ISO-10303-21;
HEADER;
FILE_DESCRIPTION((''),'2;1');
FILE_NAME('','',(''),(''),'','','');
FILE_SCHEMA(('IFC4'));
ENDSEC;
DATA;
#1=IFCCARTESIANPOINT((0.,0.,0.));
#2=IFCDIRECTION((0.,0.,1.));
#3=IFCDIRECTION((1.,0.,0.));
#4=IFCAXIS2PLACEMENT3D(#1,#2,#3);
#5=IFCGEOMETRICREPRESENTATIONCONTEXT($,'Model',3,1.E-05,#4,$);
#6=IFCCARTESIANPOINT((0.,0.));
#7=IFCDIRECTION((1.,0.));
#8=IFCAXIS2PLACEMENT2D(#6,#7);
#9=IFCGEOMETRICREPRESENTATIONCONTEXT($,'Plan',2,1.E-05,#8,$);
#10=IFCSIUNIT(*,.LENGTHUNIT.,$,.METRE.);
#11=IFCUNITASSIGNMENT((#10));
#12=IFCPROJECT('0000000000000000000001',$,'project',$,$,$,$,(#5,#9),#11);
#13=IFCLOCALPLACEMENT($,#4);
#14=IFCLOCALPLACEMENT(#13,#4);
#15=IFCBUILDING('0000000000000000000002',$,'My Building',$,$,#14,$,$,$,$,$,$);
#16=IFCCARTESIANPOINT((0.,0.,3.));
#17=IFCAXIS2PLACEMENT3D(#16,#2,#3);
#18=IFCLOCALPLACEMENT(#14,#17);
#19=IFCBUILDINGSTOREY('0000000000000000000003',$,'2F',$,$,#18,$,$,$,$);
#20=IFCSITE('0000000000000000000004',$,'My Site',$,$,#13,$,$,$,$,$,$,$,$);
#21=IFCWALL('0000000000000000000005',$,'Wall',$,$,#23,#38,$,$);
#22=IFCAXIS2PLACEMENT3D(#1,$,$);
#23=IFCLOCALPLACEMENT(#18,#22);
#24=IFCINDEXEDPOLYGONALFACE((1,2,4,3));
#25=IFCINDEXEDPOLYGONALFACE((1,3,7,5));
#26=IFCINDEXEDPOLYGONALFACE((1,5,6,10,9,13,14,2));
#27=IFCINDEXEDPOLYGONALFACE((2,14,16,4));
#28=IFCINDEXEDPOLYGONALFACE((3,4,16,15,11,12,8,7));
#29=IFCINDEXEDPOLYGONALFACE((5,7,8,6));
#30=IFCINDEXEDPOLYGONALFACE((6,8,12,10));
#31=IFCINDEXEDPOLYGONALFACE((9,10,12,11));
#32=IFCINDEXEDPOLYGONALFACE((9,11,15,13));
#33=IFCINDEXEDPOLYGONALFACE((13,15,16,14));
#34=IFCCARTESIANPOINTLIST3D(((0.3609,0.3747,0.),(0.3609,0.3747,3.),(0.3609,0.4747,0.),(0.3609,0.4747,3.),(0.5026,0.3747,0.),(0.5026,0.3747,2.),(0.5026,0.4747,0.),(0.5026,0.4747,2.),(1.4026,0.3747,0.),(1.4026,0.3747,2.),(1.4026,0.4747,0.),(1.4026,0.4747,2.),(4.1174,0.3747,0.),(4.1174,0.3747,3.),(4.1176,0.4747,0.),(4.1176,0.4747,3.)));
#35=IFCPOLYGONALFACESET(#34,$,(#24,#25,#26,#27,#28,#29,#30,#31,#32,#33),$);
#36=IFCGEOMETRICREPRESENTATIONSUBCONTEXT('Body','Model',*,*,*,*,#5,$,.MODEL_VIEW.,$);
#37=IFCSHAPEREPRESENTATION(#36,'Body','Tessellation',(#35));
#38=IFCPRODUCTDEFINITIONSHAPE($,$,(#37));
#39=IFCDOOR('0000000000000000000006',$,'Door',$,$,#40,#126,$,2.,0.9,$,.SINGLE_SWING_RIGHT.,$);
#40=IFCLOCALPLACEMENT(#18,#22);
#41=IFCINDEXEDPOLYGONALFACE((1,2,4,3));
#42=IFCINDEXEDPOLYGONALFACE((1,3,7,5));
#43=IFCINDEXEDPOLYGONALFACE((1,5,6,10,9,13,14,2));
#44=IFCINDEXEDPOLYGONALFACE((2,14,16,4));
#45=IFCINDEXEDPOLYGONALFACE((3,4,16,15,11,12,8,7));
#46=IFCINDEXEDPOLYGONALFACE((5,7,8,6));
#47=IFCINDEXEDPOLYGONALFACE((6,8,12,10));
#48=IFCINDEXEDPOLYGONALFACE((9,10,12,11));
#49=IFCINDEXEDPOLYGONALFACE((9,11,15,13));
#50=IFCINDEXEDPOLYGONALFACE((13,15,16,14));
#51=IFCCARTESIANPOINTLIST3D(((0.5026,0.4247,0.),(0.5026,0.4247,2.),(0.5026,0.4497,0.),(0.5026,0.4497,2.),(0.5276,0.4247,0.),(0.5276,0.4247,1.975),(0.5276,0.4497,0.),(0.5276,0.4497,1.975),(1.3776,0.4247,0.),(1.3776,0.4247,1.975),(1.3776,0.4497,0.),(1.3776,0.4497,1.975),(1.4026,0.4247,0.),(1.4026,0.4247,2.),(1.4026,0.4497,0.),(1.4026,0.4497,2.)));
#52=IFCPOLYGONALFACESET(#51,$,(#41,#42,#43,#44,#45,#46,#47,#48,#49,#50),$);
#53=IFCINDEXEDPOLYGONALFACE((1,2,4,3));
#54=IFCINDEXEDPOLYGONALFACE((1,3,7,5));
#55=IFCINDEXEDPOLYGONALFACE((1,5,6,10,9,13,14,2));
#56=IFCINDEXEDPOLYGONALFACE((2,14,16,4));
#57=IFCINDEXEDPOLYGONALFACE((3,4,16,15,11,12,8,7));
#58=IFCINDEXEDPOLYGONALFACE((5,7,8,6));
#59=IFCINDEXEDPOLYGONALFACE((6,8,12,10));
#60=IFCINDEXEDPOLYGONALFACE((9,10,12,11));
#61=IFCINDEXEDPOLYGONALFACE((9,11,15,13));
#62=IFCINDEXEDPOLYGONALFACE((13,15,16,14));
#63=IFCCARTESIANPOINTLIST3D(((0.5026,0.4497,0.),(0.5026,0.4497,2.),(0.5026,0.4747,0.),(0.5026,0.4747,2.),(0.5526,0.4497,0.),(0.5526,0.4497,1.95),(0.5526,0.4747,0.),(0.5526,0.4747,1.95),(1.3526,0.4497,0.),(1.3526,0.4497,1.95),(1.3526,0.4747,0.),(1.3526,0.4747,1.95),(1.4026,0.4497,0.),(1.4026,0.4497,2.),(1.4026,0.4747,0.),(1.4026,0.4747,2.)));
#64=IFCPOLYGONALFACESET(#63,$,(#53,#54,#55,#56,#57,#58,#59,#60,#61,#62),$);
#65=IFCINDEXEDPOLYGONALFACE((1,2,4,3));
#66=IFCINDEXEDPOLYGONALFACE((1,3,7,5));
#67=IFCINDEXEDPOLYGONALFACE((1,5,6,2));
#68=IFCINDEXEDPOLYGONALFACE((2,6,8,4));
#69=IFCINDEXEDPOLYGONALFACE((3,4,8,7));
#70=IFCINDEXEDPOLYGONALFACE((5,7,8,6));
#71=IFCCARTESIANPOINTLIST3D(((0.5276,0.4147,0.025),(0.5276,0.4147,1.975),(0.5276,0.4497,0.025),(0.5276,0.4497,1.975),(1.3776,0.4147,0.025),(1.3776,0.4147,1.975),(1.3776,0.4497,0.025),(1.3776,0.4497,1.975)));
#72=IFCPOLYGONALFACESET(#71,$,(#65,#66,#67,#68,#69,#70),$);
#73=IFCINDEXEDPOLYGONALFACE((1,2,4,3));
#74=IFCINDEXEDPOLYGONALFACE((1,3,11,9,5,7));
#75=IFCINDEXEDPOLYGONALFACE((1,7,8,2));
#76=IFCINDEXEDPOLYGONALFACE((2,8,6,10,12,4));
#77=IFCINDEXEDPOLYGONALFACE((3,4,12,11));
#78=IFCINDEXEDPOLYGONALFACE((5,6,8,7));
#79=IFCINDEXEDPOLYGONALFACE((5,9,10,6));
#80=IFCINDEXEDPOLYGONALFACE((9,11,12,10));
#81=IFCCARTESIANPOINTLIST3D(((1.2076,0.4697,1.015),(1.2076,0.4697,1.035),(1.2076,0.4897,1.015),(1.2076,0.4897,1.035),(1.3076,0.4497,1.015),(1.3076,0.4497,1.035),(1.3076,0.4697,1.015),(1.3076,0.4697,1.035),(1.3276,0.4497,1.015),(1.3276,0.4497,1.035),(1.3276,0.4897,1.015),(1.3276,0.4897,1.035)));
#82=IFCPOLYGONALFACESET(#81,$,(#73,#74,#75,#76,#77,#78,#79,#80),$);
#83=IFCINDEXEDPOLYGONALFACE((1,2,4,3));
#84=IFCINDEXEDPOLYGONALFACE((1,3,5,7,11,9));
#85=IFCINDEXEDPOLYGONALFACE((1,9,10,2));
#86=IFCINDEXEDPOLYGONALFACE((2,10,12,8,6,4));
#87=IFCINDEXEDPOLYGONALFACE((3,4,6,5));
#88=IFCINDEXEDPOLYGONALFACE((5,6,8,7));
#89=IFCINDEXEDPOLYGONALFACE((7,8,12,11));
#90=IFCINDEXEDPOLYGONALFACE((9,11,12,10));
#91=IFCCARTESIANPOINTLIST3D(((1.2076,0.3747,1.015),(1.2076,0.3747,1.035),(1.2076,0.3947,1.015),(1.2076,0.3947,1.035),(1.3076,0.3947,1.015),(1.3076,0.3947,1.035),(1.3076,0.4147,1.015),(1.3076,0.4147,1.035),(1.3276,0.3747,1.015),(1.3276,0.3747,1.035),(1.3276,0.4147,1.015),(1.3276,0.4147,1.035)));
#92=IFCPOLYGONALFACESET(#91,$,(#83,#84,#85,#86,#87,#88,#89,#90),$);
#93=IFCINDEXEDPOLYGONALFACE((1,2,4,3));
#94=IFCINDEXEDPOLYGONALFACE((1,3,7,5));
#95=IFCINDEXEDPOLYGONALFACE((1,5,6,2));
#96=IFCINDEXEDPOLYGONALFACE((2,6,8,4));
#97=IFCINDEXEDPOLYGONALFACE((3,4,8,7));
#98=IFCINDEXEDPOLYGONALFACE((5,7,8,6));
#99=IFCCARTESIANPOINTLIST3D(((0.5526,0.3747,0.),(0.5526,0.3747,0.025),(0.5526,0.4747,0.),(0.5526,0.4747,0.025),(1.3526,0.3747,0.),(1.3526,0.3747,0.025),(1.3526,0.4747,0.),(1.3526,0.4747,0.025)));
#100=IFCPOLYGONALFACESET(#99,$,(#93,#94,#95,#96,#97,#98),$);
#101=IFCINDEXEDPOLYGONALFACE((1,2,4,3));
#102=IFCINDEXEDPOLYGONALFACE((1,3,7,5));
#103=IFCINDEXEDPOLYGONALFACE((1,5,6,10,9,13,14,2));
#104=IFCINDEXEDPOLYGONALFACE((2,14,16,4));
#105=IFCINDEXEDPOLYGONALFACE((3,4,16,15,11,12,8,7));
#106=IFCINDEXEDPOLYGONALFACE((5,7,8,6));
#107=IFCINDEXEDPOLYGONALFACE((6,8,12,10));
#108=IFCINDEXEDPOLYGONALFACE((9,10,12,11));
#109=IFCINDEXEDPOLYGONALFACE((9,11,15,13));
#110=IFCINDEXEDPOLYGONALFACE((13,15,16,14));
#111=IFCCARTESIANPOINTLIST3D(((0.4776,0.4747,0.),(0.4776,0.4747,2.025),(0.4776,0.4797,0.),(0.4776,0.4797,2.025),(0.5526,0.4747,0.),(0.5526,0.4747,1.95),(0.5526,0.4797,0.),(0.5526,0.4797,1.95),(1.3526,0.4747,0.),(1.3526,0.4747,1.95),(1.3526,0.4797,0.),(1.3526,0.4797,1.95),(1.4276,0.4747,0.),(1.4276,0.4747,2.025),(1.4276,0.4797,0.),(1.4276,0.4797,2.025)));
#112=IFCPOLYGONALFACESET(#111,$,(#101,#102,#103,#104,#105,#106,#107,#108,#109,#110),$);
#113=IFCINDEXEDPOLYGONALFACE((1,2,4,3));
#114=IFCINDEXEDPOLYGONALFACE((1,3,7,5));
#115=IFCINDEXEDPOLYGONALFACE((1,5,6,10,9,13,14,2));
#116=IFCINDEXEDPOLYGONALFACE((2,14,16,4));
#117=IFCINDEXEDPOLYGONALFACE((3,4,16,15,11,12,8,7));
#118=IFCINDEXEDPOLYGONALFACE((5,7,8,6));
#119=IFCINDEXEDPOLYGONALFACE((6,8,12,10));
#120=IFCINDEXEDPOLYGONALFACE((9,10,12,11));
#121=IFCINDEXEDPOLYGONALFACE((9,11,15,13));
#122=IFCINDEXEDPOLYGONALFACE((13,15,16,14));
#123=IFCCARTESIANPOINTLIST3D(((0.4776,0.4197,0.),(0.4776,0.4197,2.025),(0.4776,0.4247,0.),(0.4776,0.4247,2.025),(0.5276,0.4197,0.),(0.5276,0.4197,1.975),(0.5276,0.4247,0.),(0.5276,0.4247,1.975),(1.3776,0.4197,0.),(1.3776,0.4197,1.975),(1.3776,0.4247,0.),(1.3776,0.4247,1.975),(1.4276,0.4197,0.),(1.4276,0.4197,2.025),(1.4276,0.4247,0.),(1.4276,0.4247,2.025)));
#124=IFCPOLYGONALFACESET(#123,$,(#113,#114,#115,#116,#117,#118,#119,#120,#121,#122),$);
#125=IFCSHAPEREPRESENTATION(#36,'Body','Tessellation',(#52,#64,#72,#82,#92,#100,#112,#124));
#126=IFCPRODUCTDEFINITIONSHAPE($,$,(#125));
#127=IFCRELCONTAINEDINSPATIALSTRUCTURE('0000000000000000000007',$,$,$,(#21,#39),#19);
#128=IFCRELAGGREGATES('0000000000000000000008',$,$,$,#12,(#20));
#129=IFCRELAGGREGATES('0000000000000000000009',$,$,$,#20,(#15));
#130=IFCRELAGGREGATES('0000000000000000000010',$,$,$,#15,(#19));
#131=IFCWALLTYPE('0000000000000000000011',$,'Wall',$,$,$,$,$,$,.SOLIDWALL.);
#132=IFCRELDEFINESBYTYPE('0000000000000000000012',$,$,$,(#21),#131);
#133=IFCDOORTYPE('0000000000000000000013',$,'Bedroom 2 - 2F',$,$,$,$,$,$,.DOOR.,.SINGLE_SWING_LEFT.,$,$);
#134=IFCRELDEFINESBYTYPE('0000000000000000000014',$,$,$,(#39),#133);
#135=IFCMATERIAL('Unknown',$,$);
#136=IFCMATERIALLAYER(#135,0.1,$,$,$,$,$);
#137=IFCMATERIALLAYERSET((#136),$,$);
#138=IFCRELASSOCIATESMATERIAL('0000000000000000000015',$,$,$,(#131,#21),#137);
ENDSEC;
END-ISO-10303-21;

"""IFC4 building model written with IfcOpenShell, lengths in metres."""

from ifc_helpers import new_model, entity, si_unit, frame, origin_with_axes, origin_2d_with_axis, place, context, subcontext, project, spatial, line, indexed_curve, outline, extrude, shape, source, transform, mapped, material, layer, layer_set, layer_usage, type_object, type_shapes, element, fill, save


model = new_model("IFC4")

# Units and contexts
model_context = context("Model", 3, precision=1e-05, world=origin_with_axes())
plan_context = context("Plan", 2, precision=1e-05, world=origin_2d_with_axis())
body_context_1 = subcontext(model_context, "Body", "Model", "MODEL_VIEW")
body_context_2 = subcontext(plan_context, "Body", "Plan", "PLAN_VIEW")
ifc_project = project(units=[si_unit("LENGTHUNIT", "METRE")], contexts=[model_context, plan_context])

# Site, building, storey
site_placement = place(None, origin_with_axes())
site = spatial("IfcSite", under=ifc_project, at=site_placement, Name="My Site")
building_placement = place(site_placement, origin_with_axes())
building = spatial("IfcBuilding", under=site, at=building_placement, Name="My Building")
storey_placement = place(building_placement, frame((0.0, 0.0, 3.0), z_axis=(0.0, 0.0, 1.0), x_axis=(1.0, 0.0, 0.0)))
storey = spatial("IfcBuildingStorey", under=building, at=storey_placement, Name="2F")

# Shared definitions
ifc_material = material(Name="Unknown")

# Shared definitions
ifc_layer_1 = layer(ifc_material, 0.1)
ifc_layer_set_1 = layer_set([ifc_layer_1])
wall_type = type_object("IfcWallType", Name="Wall", PredefinedType="SOLIDWALL", material=ifc_layer_set_1)

# Wall, opening, door
ifc_layer_usage_1 = layer_usage(ifc_layer_set_1, "AXIS2", "POSITIVE", 0.0)
wall_1_placement = place(storey_placement, frame((0.2609, 0.3747, 0.0), z_axis=(0.0, 0.0, 1.0), x_axis=(1.0, 0.0, 0.0)))
wall_1 = element("IfcWall", 1, at=wall_1_placement, inside=storey, type_object=wall_type, material=ifc_layer_usage_1, Name="Wall", context=body_context_1, shape_type="SweptSolid", body=[
    extrude(outline(indexed_curve([(0.1, 0.0), (0.1, 0.1), (3.8567, 0.1), (3.8565, 0.0)], segments=[line(1, 2, 3, 4, 1)])), origin_with_axes(), (0.0, 0.0, 1.0), 3.0),
])
shared_shape_1 = source(origin_with_axes(), body_context_1, "Body", "SweptSolid", [
    extrude(outline(indexed_curve([(0.0, 0.0), (0.9, 0.0), (0.9, 2.0), (0.0, 2.0)], segments=[line(1, 2, 3, 4, 1)])), frame((0.0, -0.6, 0.0), z_axis=(0.0, -1.0, 0.0), x_axis=(1.0, 0.0, 0.0)), (0.0, 0.0, -1.0), 1.2),
])
opening_1_placement = place(wall_1_placement, frame((1.1417, 0.1, 0.0), z_axis=(0.0, 0.0, 1.0), x_axis=(-1.0, 0.0, 0.0)))
opening_1 = element("IfcOpeningElement", 2, at=opening_1_placement, cuts=wall_1, PredefinedType="OPENING", context=body_context_1, shape_type="MappedRepresentation", body=[
    mapped(shared_shape_1, transform((0.0, 0.0, 0.0), x_axis=(1.0, 0.0, 0.0), y_axis=(0.0, 1.0, 0.0), z_axis=(0.0, 0.0, 1.0), scale=1.0)),
])
door_type_1 = type_object("IfcDoorType", Name="Bedroom 2 - 2F", OperationType="SINGLE_SWING_LEFT", PredefinedType="DOOR")
shared_shape_2 = source(origin_with_axes(), body_context_1, "Body", "SweptSolid", [
    extrude(outline(indexed_curve([(0.0, 0.0), (0.0, 2.0), (0.9, 2.0), (0.9, 0.0), (0.875, 0.0), (0.875, 1.975), (0.025, 1.975), (0.025, 0.0)], segments=[line(1, 2, 3, 4, 5, 6, 7, 8, 1)])), frame((0.0, 0.025, 0.0), z_axis=(0.0, -1.0, 0.0), x_axis=(1.0, 0.0, 0.0)), (0.0, 0.0, -1.0), 0.025),
    extrude(outline(indexed_curve([(0.0, 0.0), (0.0, 2.0), (0.9, 2.0), (0.9, 0.0), (0.85, 0.0), (0.85, 1.95), (0.05, 1.95), (0.05, 0.0)], segments=[line(1, 2, 3, 4, 5, 6, 7, 8, 1)])), frame((0.0, 0.0, 0.0), z_axis=(0.0, -1.0, 0.0), x_axis=(1.0, 0.0, 0.0)), (0.0, 0.0, -1.0), 0.025),
    extrude(outline(indexed_curve([(0.0, 0.0), (0.85, 0.0), (0.85, 0.035), (0.0, 0.035)], segments=[line(1, 2, 3, 4, 1)])), frame((0.025, 0.025, 0.025), z_axis=(0.0, 0.0, 1.0), x_axis=(1.0, 0.0, 0.0)), (0.0, 0.0, 1.0), 1.95),
    extrude(outline(indexed_curve([(0.0, 0.0), (0.0, -0.04), (0.12, -0.04), (0.12, -0.02), (0.02, -0.02), (0.02, 0.0)], segments=[line(1, 2, 3, 4, 5, 6, 1)])), frame((0.075, 0.025, 1.015), z_axis=(0.0, 0.0, 1.0), x_axis=(1.0, 0.0, 0.0)), (0.0, 0.0, 1.0), 0.02),
    extrude(outline(indexed_curve([(0.0, 0.0), (0.0, 0.04), (0.12, 0.04), (0.12, 0.02), (0.02, 0.02), (0.02, 0.0)], segments=[line(1, 2, 3, 4, 5, 6, 1)])), frame((0.075, 0.06, 1.015), z_axis=(0.0, 0.0, 1.0), x_axis=(1.0, 0.0, 0.0)), (0.0, 0.0, 1.0), 0.02),
    extrude(outline(indexed_curve([(0.0, 0.0), (0.8, 0.0), (0.8, 0.1), (0.0, 0.1)], segments=[line(1, 2, 3, 4, 1)])), frame((0.05, 0.0, 0.0), z_axis=(0.0, 0.0, 1.0), x_axis=(1.0, 0.0, 0.0)), (0.0, 0.0, 1.0), 0.025),
    extrude(outline(indexed_curve([(0.0, 0.0), (0.0, 2.025), (0.95, 2.025), (0.95, 0.0), (0.875, 0.0), (0.875, 1.95), (0.075, 1.95), (0.075, 0.0)], segments=[line(1, 2, 3, 4, 5, 6, 7, 8, 1)])), frame((-0.025, -0.005, 0.0), z_axis=(0.0, -1.0, 0.0), x_axis=(1.0, 0.0, 0.0)), (0.0, 0.0, -1.0), 0.005),
    extrude(outline(indexed_curve([(0.0, 0.0), (0.0, 2.025), (0.95, 2.025), (0.95, 0.0), (0.9, 0.0), (0.9, 1.975), (0.05, 1.975), (0.05, 0.0)], segments=[line(1, 2, 3, 4, 5, 6, 7, 8, 1)])), frame((-0.025, 0.05, 0.0), z_axis=(0.0, -1.0, 0.0), x_axis=(1.0, 0.0, 0.0)), (0.0, 0.0, -1.0), 0.005),
])
shared_shape_3 = source(origin_with_axes(), body_context_2, "Body", "Curve2D", [
    entity("IfcIndexedPolyCurve", entity("IfcCartesianPointList2D", [[0.0, 0.0], [0.0, 0.05], [0.025, 0.05], [0.025, 0.025], [0.05, 0.025], [0.05, 0.0]]), [entity("IfcLineIndex", [1, 2, 3, 4, 5, 6, 1])]),
    entity("IfcIndexedPolyCurve", entity("IfcCartesianPointList2D", [[0.9, 0.0], [0.9, 0.05], [0.875, 0.05], [0.875, 0.025], [0.85, 0.025], [0.85, 0.0]]), [entity("IfcLineIndex", [1, 2, 3, 4, 5, 6, 1])]),
    entity("IfcTrimmedCurve", entity("IfcEllipse", entity("IfcAxis2Placement2D", entity("IfcCartesianPoint", [0.84, 0.05]), entity("IfcDirection", [1.0, 0.0])), 0.815, 0.85), [entity("IfcCartesianPoint", [0.84, 0.9])], [entity("IfcCartesianPoint", [0.025, 0.05])], True, "CARTESIAN"),
    entity("IfcIndexedPolyCurve", entity("IfcCartesianPointList2D", [[0.875, 0.05], [0.84, 0.05], [0.84, 0.9], [0.875, 0.9]]), [entity("IfcLineIndex", [1, 2, 3, 4, 1])]),
])
type_shapes(door_type_1, [shared_shape_2, shared_shape_3])
door_1_placement = place(opening_1_placement, origin_with_axes())
door_1 = element("IfcDoor", 3, at=door_1_placement, inside=storey, type_object=door_type_1, Name="Door", OperationType="SINGLE_SWING_RIGHT", OverallHeight=2.0, OverallWidth=0.9, shapes=[
    shape(body_context_1, "Body", "MappedRepresentation", [mapped(shared_shape_2, transform((0.0, 0.0, 0.0), x_axis=(1.0, 0.0, 0.0), y_axis=(0.0, 1.0, 0.0), z_axis=(0.0, 0.0, 1.0), scale=1.0))]),
    shape(body_context_2, "Body", "MappedRepresentation", [mapped(shared_shape_3, transform((0.0, 0.0, 0.0), x_axis=(1.0, 0.0, 0.0), y_axis=(0.0, 1.0, 0.0), z_axis=(0.0, 0.0, 1.0), scale=1.0))]),
])
fill(opening_1, door_1)

save(model, "model.ifc")
